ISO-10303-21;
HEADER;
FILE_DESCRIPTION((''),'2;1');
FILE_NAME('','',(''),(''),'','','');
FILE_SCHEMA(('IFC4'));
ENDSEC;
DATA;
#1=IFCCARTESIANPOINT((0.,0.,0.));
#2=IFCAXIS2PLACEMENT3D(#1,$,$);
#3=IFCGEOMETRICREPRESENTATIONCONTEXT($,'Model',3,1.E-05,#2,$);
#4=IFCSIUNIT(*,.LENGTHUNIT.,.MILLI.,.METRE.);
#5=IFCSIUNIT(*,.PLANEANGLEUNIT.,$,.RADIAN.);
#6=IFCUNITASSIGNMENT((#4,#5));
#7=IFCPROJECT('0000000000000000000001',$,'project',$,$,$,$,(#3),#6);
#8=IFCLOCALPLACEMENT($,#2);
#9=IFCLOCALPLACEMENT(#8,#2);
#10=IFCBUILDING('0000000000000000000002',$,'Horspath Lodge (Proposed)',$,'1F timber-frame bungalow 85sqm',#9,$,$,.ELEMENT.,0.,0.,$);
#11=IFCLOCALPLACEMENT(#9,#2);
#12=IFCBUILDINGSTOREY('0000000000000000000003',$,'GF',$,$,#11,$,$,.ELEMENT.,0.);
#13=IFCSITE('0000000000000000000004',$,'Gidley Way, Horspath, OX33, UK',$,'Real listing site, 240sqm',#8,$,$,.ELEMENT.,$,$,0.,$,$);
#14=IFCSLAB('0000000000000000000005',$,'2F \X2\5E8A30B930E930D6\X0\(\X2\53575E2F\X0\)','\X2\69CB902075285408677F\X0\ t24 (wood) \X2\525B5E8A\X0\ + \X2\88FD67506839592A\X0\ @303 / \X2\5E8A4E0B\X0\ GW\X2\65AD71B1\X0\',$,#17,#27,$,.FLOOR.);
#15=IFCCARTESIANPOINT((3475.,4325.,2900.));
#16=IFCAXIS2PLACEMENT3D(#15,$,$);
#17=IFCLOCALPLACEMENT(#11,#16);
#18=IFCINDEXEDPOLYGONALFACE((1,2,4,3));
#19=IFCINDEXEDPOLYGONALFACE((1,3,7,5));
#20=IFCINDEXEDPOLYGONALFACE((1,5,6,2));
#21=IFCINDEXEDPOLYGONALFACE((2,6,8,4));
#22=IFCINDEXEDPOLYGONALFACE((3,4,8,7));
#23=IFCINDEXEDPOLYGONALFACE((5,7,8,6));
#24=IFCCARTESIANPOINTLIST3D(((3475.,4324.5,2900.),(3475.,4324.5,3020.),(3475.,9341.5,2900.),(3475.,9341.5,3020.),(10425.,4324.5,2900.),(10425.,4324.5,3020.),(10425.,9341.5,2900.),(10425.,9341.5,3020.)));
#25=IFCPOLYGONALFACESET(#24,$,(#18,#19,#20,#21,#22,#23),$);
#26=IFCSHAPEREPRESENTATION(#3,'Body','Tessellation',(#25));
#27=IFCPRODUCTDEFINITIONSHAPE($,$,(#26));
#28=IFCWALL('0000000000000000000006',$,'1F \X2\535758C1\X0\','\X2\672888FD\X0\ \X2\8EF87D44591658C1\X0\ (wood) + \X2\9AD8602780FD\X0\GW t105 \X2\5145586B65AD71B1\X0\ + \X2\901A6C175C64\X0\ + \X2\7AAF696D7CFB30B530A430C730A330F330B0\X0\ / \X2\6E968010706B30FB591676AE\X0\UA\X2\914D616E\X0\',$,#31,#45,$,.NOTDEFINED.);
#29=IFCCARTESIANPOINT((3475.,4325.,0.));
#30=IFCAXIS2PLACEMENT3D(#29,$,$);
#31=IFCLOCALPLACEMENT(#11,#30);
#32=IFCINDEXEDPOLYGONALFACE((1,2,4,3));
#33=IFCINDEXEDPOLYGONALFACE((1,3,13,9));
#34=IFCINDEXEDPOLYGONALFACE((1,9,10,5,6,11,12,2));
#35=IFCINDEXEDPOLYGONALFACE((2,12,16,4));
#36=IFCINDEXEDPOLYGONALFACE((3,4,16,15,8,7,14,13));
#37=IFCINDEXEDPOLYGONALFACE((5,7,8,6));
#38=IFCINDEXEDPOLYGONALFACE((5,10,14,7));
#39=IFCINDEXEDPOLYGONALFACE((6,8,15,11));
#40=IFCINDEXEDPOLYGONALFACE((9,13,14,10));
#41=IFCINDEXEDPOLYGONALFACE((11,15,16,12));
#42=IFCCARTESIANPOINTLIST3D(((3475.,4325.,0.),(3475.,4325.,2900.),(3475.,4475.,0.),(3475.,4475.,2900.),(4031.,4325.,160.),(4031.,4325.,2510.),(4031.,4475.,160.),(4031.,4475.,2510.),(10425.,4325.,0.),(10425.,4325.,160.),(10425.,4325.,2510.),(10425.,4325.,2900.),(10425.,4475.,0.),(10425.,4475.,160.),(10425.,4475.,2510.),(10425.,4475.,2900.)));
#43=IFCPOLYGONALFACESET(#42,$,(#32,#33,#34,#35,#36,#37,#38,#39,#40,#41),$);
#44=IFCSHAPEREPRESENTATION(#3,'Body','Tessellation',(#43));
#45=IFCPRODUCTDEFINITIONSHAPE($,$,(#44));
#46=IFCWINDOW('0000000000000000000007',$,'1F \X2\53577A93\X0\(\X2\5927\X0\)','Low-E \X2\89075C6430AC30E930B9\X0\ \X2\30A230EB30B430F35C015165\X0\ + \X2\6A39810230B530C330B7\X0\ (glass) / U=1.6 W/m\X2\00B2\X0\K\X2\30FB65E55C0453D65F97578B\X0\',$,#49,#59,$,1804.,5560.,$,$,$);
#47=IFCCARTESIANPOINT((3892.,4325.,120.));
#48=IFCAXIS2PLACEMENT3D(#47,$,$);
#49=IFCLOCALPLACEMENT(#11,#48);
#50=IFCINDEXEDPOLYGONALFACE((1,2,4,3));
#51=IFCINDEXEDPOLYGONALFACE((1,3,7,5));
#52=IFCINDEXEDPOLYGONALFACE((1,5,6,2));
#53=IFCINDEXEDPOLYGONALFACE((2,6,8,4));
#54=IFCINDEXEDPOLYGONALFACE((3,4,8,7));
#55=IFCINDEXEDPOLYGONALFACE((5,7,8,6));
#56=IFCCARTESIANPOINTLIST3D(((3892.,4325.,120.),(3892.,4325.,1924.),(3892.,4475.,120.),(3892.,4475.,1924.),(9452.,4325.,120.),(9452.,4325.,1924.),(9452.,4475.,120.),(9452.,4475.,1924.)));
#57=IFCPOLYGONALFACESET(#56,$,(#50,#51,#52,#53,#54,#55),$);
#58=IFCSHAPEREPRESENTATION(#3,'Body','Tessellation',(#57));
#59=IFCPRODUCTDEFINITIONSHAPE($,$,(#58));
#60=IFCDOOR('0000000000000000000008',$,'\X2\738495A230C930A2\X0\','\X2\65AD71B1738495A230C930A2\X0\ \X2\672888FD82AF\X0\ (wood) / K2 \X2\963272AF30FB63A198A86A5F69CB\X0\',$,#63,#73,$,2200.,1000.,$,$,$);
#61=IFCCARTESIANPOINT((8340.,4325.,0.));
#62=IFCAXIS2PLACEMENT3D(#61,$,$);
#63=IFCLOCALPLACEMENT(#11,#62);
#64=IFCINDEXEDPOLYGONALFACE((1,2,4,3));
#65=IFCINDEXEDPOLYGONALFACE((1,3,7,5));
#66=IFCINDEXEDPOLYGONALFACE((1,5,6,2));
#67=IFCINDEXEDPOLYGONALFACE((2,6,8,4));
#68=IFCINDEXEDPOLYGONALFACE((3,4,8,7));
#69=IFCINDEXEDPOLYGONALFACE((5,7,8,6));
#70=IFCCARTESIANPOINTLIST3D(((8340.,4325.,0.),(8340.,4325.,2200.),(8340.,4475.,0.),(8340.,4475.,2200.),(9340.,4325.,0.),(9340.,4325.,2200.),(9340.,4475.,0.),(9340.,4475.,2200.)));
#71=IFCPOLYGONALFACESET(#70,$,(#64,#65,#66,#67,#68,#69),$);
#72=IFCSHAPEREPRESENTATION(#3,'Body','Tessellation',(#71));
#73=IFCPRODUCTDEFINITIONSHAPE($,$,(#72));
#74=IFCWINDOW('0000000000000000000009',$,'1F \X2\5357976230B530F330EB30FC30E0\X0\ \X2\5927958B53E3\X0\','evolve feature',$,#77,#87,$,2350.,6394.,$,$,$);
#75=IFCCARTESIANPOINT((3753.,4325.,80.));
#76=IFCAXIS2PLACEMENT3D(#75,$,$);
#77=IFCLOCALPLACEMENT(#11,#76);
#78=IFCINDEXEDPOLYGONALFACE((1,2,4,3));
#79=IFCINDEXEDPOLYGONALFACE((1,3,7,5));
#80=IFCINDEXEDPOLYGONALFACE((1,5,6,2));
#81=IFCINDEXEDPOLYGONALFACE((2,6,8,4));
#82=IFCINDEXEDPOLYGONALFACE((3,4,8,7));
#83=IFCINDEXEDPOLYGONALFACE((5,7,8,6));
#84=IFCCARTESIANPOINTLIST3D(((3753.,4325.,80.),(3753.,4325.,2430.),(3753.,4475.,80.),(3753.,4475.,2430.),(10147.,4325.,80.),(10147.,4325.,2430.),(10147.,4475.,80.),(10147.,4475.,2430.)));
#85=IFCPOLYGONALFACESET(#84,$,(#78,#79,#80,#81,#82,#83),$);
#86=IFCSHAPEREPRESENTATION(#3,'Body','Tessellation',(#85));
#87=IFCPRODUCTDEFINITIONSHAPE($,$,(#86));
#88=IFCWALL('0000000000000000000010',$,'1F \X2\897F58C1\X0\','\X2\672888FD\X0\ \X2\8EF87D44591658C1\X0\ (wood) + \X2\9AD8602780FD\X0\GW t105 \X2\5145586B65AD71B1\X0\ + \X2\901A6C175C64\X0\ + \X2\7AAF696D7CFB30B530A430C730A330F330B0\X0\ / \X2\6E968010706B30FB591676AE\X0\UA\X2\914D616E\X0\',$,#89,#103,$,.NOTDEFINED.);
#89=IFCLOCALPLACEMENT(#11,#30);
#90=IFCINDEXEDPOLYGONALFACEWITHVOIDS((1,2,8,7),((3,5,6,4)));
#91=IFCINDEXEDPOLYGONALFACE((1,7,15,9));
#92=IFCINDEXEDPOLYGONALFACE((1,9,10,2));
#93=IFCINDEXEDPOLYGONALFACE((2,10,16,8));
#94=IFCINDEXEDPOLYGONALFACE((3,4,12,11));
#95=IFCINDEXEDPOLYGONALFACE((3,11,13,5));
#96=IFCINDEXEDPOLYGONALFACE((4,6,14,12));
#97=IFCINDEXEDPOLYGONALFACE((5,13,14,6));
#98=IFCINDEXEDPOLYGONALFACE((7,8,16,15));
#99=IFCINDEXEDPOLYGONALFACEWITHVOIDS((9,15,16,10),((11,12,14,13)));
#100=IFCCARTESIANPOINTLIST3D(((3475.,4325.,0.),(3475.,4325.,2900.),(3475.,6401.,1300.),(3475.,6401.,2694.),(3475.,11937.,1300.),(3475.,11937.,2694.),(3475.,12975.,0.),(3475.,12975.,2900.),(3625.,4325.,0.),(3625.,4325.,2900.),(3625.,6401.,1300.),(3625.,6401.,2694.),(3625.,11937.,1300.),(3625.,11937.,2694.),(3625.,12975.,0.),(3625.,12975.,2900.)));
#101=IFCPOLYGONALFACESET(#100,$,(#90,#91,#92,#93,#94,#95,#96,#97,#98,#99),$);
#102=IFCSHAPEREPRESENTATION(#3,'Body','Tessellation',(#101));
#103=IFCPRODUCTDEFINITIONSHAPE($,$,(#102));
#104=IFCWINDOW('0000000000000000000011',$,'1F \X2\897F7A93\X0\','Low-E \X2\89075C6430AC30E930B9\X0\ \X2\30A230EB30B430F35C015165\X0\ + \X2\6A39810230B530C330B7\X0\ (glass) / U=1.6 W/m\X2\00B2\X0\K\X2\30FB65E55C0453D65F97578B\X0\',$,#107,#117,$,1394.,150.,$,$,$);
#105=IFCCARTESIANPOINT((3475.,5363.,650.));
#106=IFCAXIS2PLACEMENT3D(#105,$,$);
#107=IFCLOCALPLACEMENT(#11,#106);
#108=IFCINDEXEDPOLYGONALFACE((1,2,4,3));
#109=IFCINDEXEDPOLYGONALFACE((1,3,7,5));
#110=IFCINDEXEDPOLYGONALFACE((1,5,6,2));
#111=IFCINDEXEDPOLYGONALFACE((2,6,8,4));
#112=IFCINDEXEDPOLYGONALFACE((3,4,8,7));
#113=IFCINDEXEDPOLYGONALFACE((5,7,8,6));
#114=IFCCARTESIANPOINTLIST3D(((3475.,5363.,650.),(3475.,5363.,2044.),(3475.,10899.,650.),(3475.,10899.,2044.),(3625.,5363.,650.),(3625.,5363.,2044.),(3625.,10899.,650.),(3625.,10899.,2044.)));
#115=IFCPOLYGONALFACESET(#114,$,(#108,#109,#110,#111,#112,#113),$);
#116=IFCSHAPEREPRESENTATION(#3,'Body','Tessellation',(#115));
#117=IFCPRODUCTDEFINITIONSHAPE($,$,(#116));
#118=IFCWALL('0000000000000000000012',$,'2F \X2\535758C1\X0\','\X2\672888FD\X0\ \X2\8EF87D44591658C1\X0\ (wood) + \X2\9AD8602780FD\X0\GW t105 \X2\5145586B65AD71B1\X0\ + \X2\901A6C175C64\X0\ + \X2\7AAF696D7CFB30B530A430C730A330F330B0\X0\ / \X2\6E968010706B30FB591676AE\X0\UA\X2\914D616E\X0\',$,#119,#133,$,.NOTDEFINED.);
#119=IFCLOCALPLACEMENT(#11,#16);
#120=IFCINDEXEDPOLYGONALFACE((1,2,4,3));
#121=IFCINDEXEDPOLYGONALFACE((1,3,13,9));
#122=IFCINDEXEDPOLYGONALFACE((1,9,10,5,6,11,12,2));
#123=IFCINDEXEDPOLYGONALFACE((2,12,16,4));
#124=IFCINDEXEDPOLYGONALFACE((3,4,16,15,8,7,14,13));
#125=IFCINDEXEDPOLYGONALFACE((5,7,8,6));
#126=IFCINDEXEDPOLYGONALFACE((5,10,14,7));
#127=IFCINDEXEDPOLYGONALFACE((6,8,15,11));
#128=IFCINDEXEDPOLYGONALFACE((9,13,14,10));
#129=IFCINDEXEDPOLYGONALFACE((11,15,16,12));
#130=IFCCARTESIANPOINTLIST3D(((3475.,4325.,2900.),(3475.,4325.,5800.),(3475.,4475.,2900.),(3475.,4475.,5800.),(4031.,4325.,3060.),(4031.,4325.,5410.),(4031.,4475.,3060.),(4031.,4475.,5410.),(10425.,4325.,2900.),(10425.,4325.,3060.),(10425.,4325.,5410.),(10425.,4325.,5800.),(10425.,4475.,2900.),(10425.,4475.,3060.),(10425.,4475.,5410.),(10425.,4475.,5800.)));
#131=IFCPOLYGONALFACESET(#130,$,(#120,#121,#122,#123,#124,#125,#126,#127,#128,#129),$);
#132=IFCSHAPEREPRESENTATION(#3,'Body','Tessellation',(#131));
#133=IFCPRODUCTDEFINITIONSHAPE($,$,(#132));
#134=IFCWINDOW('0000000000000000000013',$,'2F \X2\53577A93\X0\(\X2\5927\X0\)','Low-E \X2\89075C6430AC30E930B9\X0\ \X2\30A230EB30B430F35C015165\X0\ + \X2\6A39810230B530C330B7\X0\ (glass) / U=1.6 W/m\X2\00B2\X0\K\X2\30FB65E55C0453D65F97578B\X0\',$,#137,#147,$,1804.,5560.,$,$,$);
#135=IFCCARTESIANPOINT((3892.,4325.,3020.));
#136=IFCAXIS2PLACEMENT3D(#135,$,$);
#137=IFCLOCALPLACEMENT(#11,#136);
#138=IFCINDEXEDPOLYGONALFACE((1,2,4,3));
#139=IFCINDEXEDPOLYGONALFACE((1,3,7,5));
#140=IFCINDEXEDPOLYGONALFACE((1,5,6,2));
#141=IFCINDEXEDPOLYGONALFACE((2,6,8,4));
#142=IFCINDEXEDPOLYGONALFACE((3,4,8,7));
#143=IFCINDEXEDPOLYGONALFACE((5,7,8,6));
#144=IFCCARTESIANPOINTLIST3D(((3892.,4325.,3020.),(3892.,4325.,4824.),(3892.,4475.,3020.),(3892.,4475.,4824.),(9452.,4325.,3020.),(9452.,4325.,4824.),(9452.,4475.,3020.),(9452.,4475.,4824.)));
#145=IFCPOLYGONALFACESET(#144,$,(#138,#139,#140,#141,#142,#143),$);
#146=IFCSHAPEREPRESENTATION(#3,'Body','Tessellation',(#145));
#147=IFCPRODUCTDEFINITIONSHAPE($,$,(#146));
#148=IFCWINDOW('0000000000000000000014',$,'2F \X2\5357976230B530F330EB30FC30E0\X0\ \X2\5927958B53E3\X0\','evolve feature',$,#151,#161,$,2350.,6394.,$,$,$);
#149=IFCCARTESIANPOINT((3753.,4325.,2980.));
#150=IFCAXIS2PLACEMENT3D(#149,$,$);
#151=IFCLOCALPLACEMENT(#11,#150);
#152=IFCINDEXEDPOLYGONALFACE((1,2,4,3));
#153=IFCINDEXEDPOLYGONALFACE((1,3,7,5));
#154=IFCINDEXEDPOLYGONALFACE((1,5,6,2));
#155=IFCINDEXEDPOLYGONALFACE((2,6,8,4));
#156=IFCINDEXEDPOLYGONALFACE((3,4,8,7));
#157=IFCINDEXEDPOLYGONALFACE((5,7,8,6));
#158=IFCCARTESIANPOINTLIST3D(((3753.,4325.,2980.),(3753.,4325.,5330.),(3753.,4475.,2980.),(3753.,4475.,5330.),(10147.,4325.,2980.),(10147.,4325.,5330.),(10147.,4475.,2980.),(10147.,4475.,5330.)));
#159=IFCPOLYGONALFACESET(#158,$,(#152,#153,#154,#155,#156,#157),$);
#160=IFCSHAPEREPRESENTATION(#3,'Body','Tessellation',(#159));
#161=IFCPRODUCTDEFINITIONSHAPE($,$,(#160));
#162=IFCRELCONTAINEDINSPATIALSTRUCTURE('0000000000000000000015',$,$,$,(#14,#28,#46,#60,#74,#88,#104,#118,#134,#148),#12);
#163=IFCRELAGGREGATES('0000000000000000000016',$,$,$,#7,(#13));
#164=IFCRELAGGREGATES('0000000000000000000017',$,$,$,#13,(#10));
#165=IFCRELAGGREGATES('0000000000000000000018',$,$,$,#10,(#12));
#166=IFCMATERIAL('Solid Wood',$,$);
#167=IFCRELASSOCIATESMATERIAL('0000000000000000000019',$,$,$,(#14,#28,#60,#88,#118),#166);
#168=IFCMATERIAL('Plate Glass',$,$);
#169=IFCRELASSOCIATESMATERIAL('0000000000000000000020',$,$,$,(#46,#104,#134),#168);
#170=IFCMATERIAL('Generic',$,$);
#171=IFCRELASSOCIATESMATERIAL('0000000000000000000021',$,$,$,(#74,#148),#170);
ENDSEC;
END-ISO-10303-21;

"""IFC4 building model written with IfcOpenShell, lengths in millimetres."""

from ifc_helpers import new_model, si_unit, frame, frame_2d, origin, place, context, project, spatial, rectangle, extrude, material, element, fill, save


model = new_model("IFC4")

# Units and contexts
model_context = context("Model", 3, precision=1e-05, world=origin())
ifc_project = project(units=[si_unit("LENGTHUNIT", "METRE", prefix="MILLI"), si_unit("PLANEANGLEUNIT", "RADIAN")], contexts=[model_context])

# Site, building, storey
site_placement = place(None, origin())
site = spatial("IfcSite", under=ifc_project, at=site_placement, Name="Gidley Way, Horspath, OX33, UK", ObjectType="Real listing site, 240sqm", CompositionType="ELEMENT", RefElevation=0.0)
building_placement = place(site_placement, origin())
building = spatial("IfcBuilding", under=site, at=building_placement, Name="Horspath Lodge (Proposed)", ObjectType="1F timber-frame bungalow 85sqm", CompositionType="ELEMENT", ElevationOfRefHeight=0.0, ElevationOfTerrain=0.0)
storey_placement = place(building_placement, origin())
storey = spatial("IfcBuildingStorey", under=building, at=storey_placement, Name="GF", CompositionType="ELEMENT", Elevation=0.0)

# Slab
ifc_material_1 = material(Name="Solid Wood")
slab_1_placement = place(storey_placement, frame((3475.0, 4325.0, 2900.0)))
element("IfcSlab", 1, at=slab_1_placement, inside=storey, material=ifc_material_1, Name="2F 床スラブ(南帯)", Description="構造用合板 t24 (wood) 剛床 + 製材根太 @303 / 床下 GW断熱", PredefinedType="FLOOR", context=model_context, shape_type="SweptSolid", body=[
    extrude(rectangle(XDim=6950.0, YDim=5017.0, at=frame_2d((3475.0, 2508.0))), frame((3475.0, 4325.0, 2900.0)), (0.0, 0.0, 1.0), 120.0),
])
ifc_material_2 = material(Name="Generic")

# Wall, openings, windows, door
wall_1_placement = place(storey_placement, frame((3475.0, 4325.0, 0.0)))
wall_1 = element("IfcWall", 2, at=wall_1_placement, inside=storey, material=ifc_material_1, Name="1F 南壁", Description="木製 軸組外壁 (wood) + 高性能GW t105 充填断熱 + 通気層 + 窯業系サイディング / 準耐火・外皮UA配慮", PredefinedType="NOTDEFINED", context=model_context, shape_type="SweptSolid", body=[
    extrude(rectangle(XDim=6950.0, YDim=150.0, at=frame_2d((3475.0, 75.0))), frame((3475.0, 4325.0, 0.0)), (0.0, 0.0, 1.0), 2900.0),
])
opening_1_placement = place(storey_placement, frame((3892.0, 4325.0, 120.0)))
opening_1 = element("IfcOpeningElement", 3, at=opening_1_placement, cuts=wall_1, PredefinedType="NOTDEFINED", context=model_context, shape_type="SweptSolid", body=[
    extrude(rectangle(XDim=5560.0, YDim=150.0, at=frame_2d((2780.0, 75.0))), frame((3892.0, 4325.0, 120.0)), (0.0, 0.0, 1.0), 1804.0),
])
opening_2_placement = place(storey_placement, frame((8340.0, 4325.0, 0.0)))
opening_2 = element("IfcOpeningElement", 4, at=opening_2_placement, cuts=wall_1, PredefinedType="NOTDEFINED", context=model_context, shape_type="SweptSolid", body=[
    extrude(rectangle(XDim=1000.0, YDim=150.0, at=frame_2d((500.0, 75.0))), frame((8340.0, 4325.0, 0.0)), (0.0, 0.0, 1.0), 2200.0),
])
opening_3_placement = place(storey_placement, frame((3753.0, 4325.0, 80.0)))
opening_3 = element("IfcOpeningElement", 5, at=opening_3_placement, cuts=wall_1, PredefinedType="NOTDEFINED", context=model_context, shape_type="SweptSolid", body=[
    extrude(rectangle(XDim=6394.0, YDim=150.0, at=frame_2d((3197.0, 75.0))), frame((3753.0, 4325.0, 80.0)), (0.0, 0.0, 1.0), 2350.0),
])
ifc_material_3 = material(Name="Plate Glass")
window_1_placement = place(storey_placement, frame((3892.0, 4325.0, 120.0)))
window_1 = element("IfcWindow", 6, at=window_1_placement, inside=storey, material=ifc_material_3, Name="1F 南窓(大)", Description="Low-E 複層ガラス アルゴン封入 + 樹脂サッシ (glass) / U=1.6 W/m²K・日射取得型", OverallHeight=1804.0, OverallWidth=5560.0, context=model_context, shape_type="SweptSolid", body=[
    extrude(rectangle(XDim=5560.0, YDim=150.0, at=frame_2d((2780.0, 75.0))), frame((3892.0, 4325.0, 120.0)), (0.0, 0.0, 1.0), 1804.0),
])
fill(opening_1, window_1)
door_placement = place(storey_placement, frame((8340.0, 4325.0, 0.0)))
door = element("IfcDoor", 7, at=door_placement, inside=storey, material=ifc_material_1, Name="玄関ドア", Description="断熱玄関ドア 木製芯 (wood) / K2 防犯・採風機構", OverallHeight=2200.0, OverallWidth=1000.0, context=model_context, shape_type="SweptSolid", body=[
    extrude(rectangle(XDim=1000.0, YDim=150.0, at=frame_2d((500.0, 75.0))), frame((8340.0, 4325.0, 0.0)), (0.0, 0.0, 1.0), 2200.0),
])
fill(opening_2, door)
window_2_placement = place(storey_placement, frame((3753.0, 4325.0, 80.0)))
window_2 = element("IfcWindow", 8, at=window_2_placement, inside=storey, material=ifc_material_2, Name="1F 南面サンルーム 大開口", Description="evolve feature", OverallHeight=2350.0, OverallWidth=6394.0, context=model_context, shape_type="SweptSolid", body=[
    extrude(rectangle(XDim=6394.0, YDim=150.0, at=frame_2d((3197.0, 75.0))), frame((3753.0, 4325.0, 80.0)), (0.0, 0.0, 1.0), 2350.0),
])
fill(opening_3, window_2)

# Wall, opening, window
wall_2_placement = place(storey_placement, frame((3475.0, 4325.0, 0.0)))
wall_2 = element("IfcWall", 9, at=wall_2_placement, inside=storey, material=ifc_material_1, Name="1F 西壁", Description="木製 軸組外壁 (wood) + 高性能GW t105 充填断熱 + 通気層 + 窯業系サイディング / 準耐火・外皮UA配慮", PredefinedType="NOTDEFINED", context=model_context, shape_type="SweptSolid", body=[
    extrude(rectangle(XDim=150.0, YDim=8650.0, at=frame_2d((75.0, 4325.0))), frame((3475.0, 4325.0, 0.0)), (0.0, 0.0, 1.0), 2900.0),
])
opening_4_placement = place(storey_placement, frame((3475.0, 5363.0, 650.0)))
opening_4 = element("IfcOpeningElement", 10, at=opening_4_placement, cuts=wall_2, PredefinedType="NOTDEFINED", context=model_context, shape_type="SweptSolid", body=[
    extrude(rectangle(XDim=150.0, YDim=5536.0, at=frame_2d((75.0, 2768.0))), frame((3475.0, 5363.0, 650.0)), (0.0, 0.0, 1.0), 1394.0),
])
window_3_placement = place(storey_placement, frame((3475.0, 5363.0, 650.0)))
window_3 = element("IfcWindow", 11, at=window_3_placement, inside=storey, material=ifc_material_3, Name="1F 西窓", Description="Low-E 複層ガラス アルゴン封入 + 樹脂サッシ (glass) / U=1.6 W/m²K・日射取得型", OverallHeight=1394.0, OverallWidth=150.0, context=model_context, shape_type="SweptSolid", body=[
    extrude(rectangle(XDim=150.0, YDim=5536.0, at=frame_2d((75.0, 2768.0))), frame((3475.0, 5363.0, 650.0)), (0.0, 0.0, 1.0), 1394.0),
])
fill(opening_4, window_3)

# Wall, openings, windows
wall_3_placement = place(storey_placement, frame((3475.0, 4325.0, 2900.0)))
wall_3 = element("IfcWall", 12, at=wall_3_placement, inside=storey, material=ifc_material_1, Name="2F 南壁", Description="木製 軸組外壁 (wood) + 高性能GW t105 充填断熱 + 通気層 + 窯業系サイディング / 準耐火・外皮UA配慮", PredefinedType="NOTDEFINED", context=model_context, shape_type="SweptSolid", body=[
    extrude(rectangle(XDim=6950.0, YDim=150.0, at=frame_2d((3475.0, 75.0))), frame((3475.0, 4325.0, 2900.0)), (0.0, 0.0, 1.0), 2900.0),
])
opening_5_placement = place(storey_placement, frame((3892.0, 4325.0, 3020.0)))
opening_5 = element("IfcOpeningElement", 13, at=opening_5_placement, cuts=wall_3, PredefinedType="NOTDEFINED", context=model_context, shape_type="SweptSolid", body=[
    extrude(rectangle(XDim=5560.0, YDim=150.0, at=frame_2d((2780.0, 75.0))), frame((3892.0, 4325.0, 3020.0)), (0.0, 0.0, 1.0), 1804.0),
])
opening_6_placement = place(storey_placement, frame((3753.0, 4325.0, 2980.0)))
opening_6 = element("IfcOpeningElement", 14, at=opening_6_placement, cuts=wall_3, PredefinedType="NOTDEFINED", context=model_context, shape_type="SweptSolid", body=[
    extrude(rectangle(XDim=6394.0, YDim=150.0, at=frame_2d((3197.0, 75.0))), frame((3753.0, 4325.0, 2980.0)), (0.0, 0.0, 1.0), 2350.0),
])
window_4_placement = place(storey_placement, frame((3892.0, 4325.0, 3020.0)))
window_4 = element("IfcWindow", 15, at=window_4_placement, inside=storey, material=ifc_material_3, Name="2F 南窓(大)", Description="Low-E 複層ガラス アルゴン封入 + 樹脂サッシ (glass) / U=1.6 W/m²K・日射取得型", OverallHeight=1804.0, OverallWidth=5560.0, context=model_context, shape_type="SweptSolid", body=[
    extrude(rectangle(XDim=5560.0, YDim=150.0, at=frame_2d((2780.0, 75.0))), frame((3892.0, 4325.0, 3020.0)), (0.0, 0.0, 1.0), 1804.0),
])
fill(opening_5, window_4)
window_5_placement = place(storey_placement, frame((3753.0, 4325.0, 2980.0)))
window_5 = element("IfcWindow", 16, at=window_5_placement, inside=storey, material=ifc_material_2, Name="2F 南面サンルーム 大開口", Description="evolve feature", OverallHeight=2350.0, OverallWidth=6394.0, context=model_context, shape_type="SweptSolid", body=[
    extrude(rectangle(XDim=6394.0, YDim=150.0, at=frame_2d((3197.0, 75.0))), frame((3753.0, 4325.0, 2980.0)), (0.0, 0.0, 1.0), 2350.0),
])
fill(opening_6, window_5)

save(model, "model.ifc")
